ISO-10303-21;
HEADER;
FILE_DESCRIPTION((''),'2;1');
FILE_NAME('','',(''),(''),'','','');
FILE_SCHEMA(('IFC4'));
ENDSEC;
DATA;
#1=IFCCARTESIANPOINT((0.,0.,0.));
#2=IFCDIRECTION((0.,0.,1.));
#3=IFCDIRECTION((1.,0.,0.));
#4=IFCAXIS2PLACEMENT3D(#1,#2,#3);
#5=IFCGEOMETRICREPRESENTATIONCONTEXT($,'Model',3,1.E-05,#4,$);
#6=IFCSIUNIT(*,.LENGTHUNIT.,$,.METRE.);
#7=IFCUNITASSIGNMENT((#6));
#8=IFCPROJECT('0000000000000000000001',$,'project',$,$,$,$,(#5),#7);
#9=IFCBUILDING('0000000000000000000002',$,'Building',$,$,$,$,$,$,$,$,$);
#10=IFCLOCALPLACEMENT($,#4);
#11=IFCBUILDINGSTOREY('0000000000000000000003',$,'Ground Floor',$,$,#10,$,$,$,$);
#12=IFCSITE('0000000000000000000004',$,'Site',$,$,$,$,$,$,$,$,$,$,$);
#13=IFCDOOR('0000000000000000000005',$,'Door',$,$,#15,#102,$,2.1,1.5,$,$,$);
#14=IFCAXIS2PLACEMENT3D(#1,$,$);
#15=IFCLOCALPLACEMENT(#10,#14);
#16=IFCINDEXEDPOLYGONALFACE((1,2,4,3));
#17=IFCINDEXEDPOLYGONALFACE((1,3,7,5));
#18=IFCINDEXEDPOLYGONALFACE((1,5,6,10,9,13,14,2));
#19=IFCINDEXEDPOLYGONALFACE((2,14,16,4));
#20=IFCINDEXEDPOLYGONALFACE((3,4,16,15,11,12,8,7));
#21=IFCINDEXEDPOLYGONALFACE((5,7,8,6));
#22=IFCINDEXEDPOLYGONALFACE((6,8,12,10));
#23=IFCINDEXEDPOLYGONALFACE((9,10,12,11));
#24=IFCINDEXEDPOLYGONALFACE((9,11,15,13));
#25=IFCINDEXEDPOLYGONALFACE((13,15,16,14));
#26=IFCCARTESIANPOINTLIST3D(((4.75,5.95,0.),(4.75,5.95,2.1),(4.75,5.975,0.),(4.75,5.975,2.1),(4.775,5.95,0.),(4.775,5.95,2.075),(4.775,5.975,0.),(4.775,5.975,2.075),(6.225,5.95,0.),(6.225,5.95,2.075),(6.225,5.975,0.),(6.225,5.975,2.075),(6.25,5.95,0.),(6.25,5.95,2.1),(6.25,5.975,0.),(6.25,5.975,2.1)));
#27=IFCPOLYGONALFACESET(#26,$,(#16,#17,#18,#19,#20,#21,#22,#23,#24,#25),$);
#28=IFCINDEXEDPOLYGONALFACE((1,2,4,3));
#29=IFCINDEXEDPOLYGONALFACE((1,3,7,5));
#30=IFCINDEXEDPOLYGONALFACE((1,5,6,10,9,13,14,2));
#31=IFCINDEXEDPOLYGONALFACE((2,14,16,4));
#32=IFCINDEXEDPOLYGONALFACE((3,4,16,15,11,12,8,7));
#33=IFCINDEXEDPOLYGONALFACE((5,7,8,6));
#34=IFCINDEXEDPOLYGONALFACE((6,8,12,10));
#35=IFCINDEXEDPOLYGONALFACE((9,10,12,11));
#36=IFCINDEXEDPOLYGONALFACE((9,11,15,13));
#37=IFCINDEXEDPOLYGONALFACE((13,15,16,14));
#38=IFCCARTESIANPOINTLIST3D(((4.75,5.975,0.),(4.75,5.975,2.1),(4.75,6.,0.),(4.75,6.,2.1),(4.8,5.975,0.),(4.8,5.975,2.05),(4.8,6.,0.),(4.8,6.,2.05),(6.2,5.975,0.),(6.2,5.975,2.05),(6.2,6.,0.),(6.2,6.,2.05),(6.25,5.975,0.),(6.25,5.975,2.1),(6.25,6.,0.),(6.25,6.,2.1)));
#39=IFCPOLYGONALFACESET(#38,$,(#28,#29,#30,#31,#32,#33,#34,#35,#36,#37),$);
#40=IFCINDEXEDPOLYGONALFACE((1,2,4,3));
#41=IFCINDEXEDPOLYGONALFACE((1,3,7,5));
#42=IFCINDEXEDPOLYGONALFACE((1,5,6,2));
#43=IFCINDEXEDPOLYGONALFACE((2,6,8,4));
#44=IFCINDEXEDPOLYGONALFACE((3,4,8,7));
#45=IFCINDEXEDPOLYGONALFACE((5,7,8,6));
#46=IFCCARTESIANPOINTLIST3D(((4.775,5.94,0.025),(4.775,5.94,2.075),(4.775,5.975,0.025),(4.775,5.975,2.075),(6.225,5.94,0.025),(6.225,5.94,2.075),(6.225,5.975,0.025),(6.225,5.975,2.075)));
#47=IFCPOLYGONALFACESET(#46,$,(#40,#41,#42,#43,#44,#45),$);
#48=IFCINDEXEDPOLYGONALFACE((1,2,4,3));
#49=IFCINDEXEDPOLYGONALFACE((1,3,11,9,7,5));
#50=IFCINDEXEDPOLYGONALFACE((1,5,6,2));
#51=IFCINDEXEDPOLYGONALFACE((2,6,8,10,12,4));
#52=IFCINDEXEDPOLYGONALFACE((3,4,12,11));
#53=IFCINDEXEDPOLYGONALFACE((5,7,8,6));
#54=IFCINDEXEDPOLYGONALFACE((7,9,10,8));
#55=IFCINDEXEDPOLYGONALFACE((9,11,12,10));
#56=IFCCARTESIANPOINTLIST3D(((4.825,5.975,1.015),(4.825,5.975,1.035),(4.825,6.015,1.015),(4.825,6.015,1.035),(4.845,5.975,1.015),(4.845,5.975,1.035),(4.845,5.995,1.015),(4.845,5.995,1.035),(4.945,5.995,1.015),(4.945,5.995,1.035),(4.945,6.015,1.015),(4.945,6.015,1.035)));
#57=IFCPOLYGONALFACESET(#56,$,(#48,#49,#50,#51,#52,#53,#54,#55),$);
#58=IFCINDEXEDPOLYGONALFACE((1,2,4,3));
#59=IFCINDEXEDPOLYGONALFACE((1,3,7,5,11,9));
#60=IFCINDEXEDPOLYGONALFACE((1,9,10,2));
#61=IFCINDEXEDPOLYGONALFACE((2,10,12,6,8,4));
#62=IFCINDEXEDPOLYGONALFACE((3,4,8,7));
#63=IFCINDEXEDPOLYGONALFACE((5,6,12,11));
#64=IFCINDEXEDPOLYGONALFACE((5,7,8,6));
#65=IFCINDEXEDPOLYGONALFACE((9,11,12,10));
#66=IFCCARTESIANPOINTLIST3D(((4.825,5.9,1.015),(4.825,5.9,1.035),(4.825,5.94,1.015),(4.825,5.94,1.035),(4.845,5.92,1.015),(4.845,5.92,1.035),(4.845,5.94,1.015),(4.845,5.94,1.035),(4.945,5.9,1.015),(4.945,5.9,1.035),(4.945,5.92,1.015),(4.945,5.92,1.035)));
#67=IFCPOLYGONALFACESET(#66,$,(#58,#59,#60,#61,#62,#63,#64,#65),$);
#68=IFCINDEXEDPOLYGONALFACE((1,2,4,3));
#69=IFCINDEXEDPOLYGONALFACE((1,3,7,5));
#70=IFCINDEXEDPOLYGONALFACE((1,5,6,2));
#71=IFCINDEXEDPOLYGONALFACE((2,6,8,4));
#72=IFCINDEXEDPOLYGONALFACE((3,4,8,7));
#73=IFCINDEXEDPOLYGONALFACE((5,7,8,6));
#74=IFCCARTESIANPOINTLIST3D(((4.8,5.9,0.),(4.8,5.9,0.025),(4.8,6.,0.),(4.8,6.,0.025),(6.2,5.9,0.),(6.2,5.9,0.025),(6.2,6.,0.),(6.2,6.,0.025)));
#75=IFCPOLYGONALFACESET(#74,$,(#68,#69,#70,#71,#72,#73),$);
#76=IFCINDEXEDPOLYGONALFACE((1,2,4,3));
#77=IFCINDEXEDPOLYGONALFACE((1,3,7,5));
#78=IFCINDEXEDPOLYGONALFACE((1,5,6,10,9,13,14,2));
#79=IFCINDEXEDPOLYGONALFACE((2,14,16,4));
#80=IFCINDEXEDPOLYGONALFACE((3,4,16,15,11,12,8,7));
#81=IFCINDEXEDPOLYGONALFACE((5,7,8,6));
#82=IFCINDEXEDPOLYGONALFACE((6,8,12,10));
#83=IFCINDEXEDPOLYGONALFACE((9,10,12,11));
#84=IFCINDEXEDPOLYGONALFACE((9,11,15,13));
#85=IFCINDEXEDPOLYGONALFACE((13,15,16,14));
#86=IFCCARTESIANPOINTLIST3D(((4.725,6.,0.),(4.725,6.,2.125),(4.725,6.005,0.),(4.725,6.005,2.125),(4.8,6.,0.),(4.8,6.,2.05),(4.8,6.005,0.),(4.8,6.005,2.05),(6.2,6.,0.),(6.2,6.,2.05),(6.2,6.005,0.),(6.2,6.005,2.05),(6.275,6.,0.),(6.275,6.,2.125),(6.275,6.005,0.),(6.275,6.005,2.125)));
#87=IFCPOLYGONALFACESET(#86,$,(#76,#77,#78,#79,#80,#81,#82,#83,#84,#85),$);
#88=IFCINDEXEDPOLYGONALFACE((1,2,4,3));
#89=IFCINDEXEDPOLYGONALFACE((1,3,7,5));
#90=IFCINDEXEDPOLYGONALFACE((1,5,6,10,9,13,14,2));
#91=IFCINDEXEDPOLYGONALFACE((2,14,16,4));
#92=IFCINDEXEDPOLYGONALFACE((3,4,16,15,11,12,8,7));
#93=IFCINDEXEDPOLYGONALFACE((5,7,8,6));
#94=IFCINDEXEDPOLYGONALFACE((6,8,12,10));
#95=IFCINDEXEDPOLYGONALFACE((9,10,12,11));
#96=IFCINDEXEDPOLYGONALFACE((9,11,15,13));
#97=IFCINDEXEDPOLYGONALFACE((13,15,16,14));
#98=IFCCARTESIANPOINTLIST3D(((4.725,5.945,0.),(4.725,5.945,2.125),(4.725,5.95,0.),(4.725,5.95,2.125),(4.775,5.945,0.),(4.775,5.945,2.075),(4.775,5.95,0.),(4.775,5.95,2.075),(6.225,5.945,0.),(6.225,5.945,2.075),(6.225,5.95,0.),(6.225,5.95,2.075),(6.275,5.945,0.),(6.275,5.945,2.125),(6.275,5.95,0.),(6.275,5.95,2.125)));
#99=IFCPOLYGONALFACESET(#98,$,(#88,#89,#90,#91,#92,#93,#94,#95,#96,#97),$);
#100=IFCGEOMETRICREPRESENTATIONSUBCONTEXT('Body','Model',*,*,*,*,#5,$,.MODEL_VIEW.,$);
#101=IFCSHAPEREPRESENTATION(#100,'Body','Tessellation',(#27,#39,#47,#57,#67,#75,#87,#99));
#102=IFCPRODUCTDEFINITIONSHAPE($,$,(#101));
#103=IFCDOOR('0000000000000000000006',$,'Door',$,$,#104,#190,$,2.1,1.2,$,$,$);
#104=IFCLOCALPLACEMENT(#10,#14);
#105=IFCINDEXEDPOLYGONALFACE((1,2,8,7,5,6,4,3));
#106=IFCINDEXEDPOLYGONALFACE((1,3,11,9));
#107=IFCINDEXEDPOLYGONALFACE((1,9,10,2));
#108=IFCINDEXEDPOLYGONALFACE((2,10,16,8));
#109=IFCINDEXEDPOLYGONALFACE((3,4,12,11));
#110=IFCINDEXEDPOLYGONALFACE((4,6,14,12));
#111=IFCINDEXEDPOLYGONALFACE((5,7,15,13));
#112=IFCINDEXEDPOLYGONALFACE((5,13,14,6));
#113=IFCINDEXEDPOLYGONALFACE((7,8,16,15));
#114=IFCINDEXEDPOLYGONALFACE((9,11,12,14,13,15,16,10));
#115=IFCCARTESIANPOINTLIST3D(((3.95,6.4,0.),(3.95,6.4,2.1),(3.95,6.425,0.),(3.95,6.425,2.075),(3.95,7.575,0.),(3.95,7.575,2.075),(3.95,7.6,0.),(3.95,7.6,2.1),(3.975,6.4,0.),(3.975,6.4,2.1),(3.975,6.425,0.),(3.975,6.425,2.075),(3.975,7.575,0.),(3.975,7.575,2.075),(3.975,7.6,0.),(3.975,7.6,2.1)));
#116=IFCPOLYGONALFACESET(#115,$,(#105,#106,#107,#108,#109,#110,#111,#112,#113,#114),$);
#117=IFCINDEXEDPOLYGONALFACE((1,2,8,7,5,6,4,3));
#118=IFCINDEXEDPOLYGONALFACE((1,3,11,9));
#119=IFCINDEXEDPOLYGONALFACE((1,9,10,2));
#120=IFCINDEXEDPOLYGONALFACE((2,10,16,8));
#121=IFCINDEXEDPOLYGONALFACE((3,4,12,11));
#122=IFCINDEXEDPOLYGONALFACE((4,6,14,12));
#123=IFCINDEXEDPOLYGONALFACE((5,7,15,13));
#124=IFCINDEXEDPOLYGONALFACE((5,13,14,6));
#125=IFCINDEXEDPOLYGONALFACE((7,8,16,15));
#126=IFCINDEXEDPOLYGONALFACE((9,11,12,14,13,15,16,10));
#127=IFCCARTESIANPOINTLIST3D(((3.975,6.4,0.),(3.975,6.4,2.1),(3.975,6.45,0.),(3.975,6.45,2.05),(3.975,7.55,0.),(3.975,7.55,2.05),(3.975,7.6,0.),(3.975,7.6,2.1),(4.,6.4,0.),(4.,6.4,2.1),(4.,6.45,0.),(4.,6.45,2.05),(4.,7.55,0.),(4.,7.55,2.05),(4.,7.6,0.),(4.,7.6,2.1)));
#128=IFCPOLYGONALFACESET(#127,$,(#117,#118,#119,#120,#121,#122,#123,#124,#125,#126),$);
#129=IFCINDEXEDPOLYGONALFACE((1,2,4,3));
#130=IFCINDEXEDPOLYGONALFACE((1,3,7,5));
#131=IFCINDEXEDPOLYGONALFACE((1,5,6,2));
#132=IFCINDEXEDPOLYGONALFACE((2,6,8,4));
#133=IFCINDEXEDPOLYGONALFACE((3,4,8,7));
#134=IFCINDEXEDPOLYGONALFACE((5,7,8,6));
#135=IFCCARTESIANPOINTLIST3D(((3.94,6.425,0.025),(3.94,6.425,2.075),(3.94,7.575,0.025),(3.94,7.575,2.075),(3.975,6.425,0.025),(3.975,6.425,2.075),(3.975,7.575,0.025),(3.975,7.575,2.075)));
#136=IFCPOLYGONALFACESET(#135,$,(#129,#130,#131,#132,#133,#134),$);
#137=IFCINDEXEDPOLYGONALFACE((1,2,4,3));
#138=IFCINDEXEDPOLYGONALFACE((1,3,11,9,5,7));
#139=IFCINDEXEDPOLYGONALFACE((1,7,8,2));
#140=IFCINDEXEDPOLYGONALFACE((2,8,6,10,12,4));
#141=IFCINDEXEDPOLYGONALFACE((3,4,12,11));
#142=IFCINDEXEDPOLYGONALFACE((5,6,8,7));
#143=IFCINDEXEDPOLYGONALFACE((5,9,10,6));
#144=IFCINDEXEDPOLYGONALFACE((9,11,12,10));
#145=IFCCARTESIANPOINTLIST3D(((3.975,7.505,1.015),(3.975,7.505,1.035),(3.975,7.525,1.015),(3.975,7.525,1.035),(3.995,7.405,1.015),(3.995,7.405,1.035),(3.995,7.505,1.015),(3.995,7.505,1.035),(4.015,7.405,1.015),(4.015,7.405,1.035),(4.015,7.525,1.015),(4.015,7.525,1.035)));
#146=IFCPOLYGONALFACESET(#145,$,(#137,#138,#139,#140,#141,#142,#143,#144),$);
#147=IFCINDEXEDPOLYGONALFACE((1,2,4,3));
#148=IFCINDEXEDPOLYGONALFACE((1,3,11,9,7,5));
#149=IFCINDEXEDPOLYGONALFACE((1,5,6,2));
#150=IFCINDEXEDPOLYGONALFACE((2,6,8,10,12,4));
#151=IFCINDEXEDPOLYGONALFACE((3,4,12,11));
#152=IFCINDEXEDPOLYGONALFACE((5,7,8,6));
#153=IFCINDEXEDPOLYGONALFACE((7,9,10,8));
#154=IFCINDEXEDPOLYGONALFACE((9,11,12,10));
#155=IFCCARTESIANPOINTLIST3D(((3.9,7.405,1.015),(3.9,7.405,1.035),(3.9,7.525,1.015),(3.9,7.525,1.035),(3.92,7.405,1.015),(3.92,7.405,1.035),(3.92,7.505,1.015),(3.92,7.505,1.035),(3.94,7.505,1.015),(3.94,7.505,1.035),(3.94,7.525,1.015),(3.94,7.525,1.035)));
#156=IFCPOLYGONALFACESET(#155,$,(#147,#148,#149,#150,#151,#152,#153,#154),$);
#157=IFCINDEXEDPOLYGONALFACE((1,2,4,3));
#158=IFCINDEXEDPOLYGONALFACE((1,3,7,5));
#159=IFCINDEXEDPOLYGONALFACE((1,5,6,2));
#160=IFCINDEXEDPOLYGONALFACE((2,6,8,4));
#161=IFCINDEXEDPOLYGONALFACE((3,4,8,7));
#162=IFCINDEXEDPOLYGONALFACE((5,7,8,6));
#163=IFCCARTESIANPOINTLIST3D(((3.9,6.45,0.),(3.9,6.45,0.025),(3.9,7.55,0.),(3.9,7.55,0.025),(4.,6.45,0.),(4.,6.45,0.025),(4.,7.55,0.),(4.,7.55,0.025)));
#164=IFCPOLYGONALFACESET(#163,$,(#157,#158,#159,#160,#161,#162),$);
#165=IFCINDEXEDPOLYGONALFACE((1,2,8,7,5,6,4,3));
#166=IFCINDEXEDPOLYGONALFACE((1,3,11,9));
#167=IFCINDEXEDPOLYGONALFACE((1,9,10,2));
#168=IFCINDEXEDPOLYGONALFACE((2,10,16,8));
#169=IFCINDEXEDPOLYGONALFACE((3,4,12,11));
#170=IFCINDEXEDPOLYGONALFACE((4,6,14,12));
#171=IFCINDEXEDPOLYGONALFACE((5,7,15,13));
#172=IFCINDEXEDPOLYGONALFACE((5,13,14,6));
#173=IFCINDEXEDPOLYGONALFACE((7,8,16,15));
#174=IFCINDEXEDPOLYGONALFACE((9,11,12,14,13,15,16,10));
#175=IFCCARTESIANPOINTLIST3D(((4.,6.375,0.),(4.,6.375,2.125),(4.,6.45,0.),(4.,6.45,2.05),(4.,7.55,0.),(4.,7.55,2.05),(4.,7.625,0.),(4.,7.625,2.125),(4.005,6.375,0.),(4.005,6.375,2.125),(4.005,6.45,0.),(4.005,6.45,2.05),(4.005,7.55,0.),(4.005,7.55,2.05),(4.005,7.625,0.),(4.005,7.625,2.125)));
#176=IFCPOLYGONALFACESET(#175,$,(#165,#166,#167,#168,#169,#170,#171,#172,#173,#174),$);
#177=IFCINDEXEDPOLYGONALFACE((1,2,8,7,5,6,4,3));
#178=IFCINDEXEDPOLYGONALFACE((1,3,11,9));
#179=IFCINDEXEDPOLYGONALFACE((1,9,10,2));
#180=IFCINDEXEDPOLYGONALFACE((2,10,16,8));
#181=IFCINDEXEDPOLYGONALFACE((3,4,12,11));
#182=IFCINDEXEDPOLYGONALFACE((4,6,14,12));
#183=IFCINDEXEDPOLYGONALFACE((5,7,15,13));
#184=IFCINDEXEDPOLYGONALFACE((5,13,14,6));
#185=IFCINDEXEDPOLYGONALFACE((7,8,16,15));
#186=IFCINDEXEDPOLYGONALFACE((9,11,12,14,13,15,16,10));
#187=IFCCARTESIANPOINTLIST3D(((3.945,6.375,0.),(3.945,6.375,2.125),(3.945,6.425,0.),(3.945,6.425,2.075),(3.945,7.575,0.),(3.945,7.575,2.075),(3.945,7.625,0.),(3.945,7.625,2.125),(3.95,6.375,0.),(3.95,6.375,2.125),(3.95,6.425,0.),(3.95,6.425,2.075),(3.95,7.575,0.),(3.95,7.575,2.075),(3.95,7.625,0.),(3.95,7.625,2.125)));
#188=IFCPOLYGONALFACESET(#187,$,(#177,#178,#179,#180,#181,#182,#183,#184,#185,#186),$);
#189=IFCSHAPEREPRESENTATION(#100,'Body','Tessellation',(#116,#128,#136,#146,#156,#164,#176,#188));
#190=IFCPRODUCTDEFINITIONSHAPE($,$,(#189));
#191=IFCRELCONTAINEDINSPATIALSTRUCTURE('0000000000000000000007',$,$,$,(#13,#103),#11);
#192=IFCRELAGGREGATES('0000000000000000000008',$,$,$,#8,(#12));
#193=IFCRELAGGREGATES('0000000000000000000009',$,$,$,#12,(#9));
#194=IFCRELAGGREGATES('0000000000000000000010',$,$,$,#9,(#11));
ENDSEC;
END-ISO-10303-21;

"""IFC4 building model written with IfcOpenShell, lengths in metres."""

from ifc_helpers import new_model, si_unit, frame, origin_with_axes, place, context, subcontext, project, spatial, line, indexed_curve, outline, extrude, element, save


model = new_model("IFC4")

# Units and contexts
model_context = context("Model", 3, precision=1e-05, world=origin_with_axes())
body_context = subcontext(model_context, "Body", "Model", "MODEL_VIEW")
ifc_project = project(units=[si_unit("LENGTHUNIT", "METRE")], contexts=[model_context])

# Site, building, storey
site = spatial("IfcSite", under=ifc_project, Name="Site")
building = spatial("IfcBuilding", under=site, Name="Building")
storey_placement = place(None, origin_with_axes())
storey = spatial("IfcBuildingStorey", under=building, at=storey_placement, Name="Ground Floor")

# Doors
door_1_placement = place(storey_placement, frame((6.25, 6.0, 0.0), z_axis=(0.0, 0.0, 1.0), x_axis=(-1.0, 0.0, 0.0)))
element("IfcDoor", 1, at=door_1_placement, inside=storey, Name="Door", OverallHeight=2.1, OverallWidth=1.5, context=body_context, shape_type="SweptSolid", body=[
    extrude(outline(indexed_curve([(0.0, 0.0), (0.0, 2.1), (1.5, 2.1), (1.5, 0.0), (1.475, 0.0), (1.475, 2.075), (0.025, 2.075), (0.025, 0.0)], segments=[line(1, 2, 3, 4, 5, 6, 7, 8, 1)])), frame((0.0, 0.025, 0.0), z_axis=(0.0, -1.0, 0.0), x_axis=(1.0, 0.0, 0.0)), (0.0, 0.0, -1.0), 0.025),
    extrude(outline(indexed_curve([(0.0, 0.0), (0.0, 2.1), (1.5, 2.1), (1.5, 0.0), (1.45, 0.0), (1.45, 2.05), (0.05, 2.05), (0.05, 0.0)], segments=[line(1, 2, 3, 4, 5, 6, 7, 8, 1)])), frame((0.0, 0.0, 0.0), z_axis=(0.0, -1.0, 0.0), x_axis=(1.0, 0.0, 0.0)), (0.0, 0.0, -1.0), 0.025),
    extrude(outline(indexed_curve([(0.0, 0.0), (1.45, 0.0), (1.45, 0.035), (0.0, 0.035)], segments=[line(1, 2, 3, 4, 1)])), frame((0.025, 0.025, 0.025), z_axis=(0.0, 0.0, 1.0), x_axis=(1.0, 0.0, 0.0)), (0.0, 0.0, 1.0), 2.05),
    extrude(outline(indexed_curve([(0.0, 0.0), (0.0, -0.04), (-0.12, -0.04), (-0.12, -0.02), (-0.02, -0.02), (-0.02, 0.0)], segments=[line(1, 2, 3, 4, 5, 6, 1)])), frame((1.425, 0.025, 1.015), z_axis=(0.0, 0.0, 1.0), x_axis=(1.0, 0.0, 0.0)), (0.0, 0.0, 1.0), 0.02),
    extrude(outline(indexed_curve([(0.0, 0.0), (0.0, 0.04), (-0.12, 0.04), (-0.12, 0.02), (-0.02, 0.02), (-0.02, 0.0)], segments=[line(1, 2, 3, 4, 5, 6, 1)])), frame((1.425, 0.06, 1.015), z_axis=(0.0, 0.0, 1.0), x_axis=(1.0, 0.0, 0.0)), (0.0, 0.0, 1.0), 0.02),
    extrude(outline(indexed_curve([(0.0, 0.0), (1.4, 0.0), (1.4, 0.1), (0.0, 0.1)], segments=[line(1, 2, 3, 4, 1)])), frame((0.05, 0.0, 0.0), z_axis=(0.0, 0.0, 1.0), x_axis=(1.0, 0.0, 0.0)), (0.0, 0.0, 1.0), 0.025),
    extrude(outline(indexed_curve([(0.0, 0.0), (0.0, 2.125), (1.55, 2.125), (1.55, 0.0), (1.475, 0.0), (1.475, 2.05), (0.075, 2.05), (0.075, 0.0)], segments=[line(1, 2, 3, 4, 5, 6, 7, 8, 1)])), frame((-0.025, -0.005, 0.0), z_axis=(0.0, -1.0, 0.0), x_axis=(1.0, 0.0, 0.0)), (0.0, 0.0, -1.0), 0.005),
    extrude(outline(indexed_curve([(0.0, 0.0), (0.0, 2.125), (1.55, 2.125), (1.55, 0.0), (1.5, 0.0), (1.5, 2.075), (0.05, 2.075), (0.05, 0.0)], segments=[line(1, 2, 3, 4, 5, 6, 7, 8, 1)])), frame((-0.025, 0.05, 0.0), z_axis=(0.0, -1.0, 0.0), x_axis=(1.0, 0.0, 0.0)), (0.0, 0.0, -1.0), 0.005),
])
door_2_placement = place(storey_placement, frame((4.0, 6.4, 0.0), z_axis=(0.0, 0.0, 1.0), x_axis=(0.0, 1.0, 0.0)))
element("IfcDoor", 2, at=door_2_placement, inside=storey, Name="Door", OverallHeight=2.1, OverallWidth=1.2, context=body_context, shape_type="SweptSolid", body=[
    extrude(outline(indexed_curve([(0.0, 0.0), (0.0, 2.1), (1.2, 2.1), (1.2, 0.0), (1.175, 0.0), (1.175, 2.075), (0.025, 2.075), (0.025, 0.0)], segments=[line(1, 2, 3, 4, 5, 6, 7, 8, 1)])), frame((0.0, 0.025, 0.0), z_axis=(0.0, -1.0, 0.0), x_axis=(1.0, 0.0, 0.0)), (0.0, 0.0, -1.0), 0.025),
    extrude(outline(indexed_curve([(0.0, 0.0), (0.0, 2.1), (1.2, 2.1), (1.2, 0.0), (1.15, 0.0), (1.15, 2.05), (0.05, 2.05), (0.05, 0.0)], segments=[line(1, 2, 3, 4, 5, 6, 7, 8, 1)])), frame((0.0, 0.0, 0.0), z_axis=(0.0, -1.0, 0.0), x_axis=(1.0, 0.0, 0.0)), (0.0, 0.0, -1.0), 0.025),
    extrude(outline(indexed_curve([(0.0, 0.0), (1.15, 0.0), (1.15, 0.035), (0.0, 0.035)], segments=[line(1, 2, 3, 4, 1)])), frame((0.025, 0.025, 0.025), z_axis=(0.0, 0.0, 1.0), x_axis=(1.0, 0.0, 0.0)), (0.0, 0.0, 1.0), 2.05),
    extrude(outline(indexed_curve([(0.0, 0.0), (0.0, -0.04), (-0.12, -0.04), (-0.12, -0.02), (-0.02, -0.02), (-0.02, 0.0)], segments=[line(1, 2, 3, 4, 5, 6, 1)])), frame((1.125, 0.025, 1.015), z_axis=(0.0, 0.0, 1.0), x_axis=(1.0, 0.0, 0.0)), (0.0, 0.0, 1.0), 0.02),
    extrude(outline(indexed_curve([(0.0, 0.0), (0.0, 0.04), (-0.12, 0.04), (-0.12, 0.02), (-0.02, 0.02), (-0.02, 0.0)], segments=[line(1, 2, 3, 4, 5, 6, 1)])), frame((1.125, 0.06, 1.015), z_axis=(0.0, 0.0, 1.0), x_axis=(1.0, 0.0, 0.0)), (0.0, 0.0, 1.0), 0.02),
    extrude(outline(indexed_curve([(0.0, 0.0), (1.1, 0.0), (1.1, 0.1), (0.0, 0.1)], segments=[line(1, 2, 3, 4, 1)])), frame((0.05, 0.0, 0.0), z_axis=(0.0, 0.0, 1.0), x_axis=(1.0, 0.0, 0.0)), (0.0, 0.0, 1.0), 0.025),
    extrude(outline(indexed_curve([(0.0, 0.0), (0.0, 2.125), (1.25, 2.125), (1.25, 0.0), (1.175, 0.0), (1.175, 2.05), (0.075, 2.05), (0.075, 0.0)], segments=[line(1, 2, 3, 4, 5, 6, 7, 8, 1)])), frame((-0.025, -0.005, 0.0), z_axis=(0.0, -1.0, 0.0), x_axis=(1.0, 0.0, 0.0)), (0.0, 0.0, -1.0), 0.005),
    extrude(outline(indexed_curve([(0.0, 0.0), (0.0, 2.125), (1.25, 2.125), (1.25, 0.0), (1.2, 0.0), (1.2, 2.075), (0.05, 2.075), (0.05, 0.0)], segments=[line(1, 2, 3, 4, 5, 6, 7, 8, 1)])), frame((-0.025, 0.05, 0.0), z_axis=(0.0, -1.0, 0.0), x_axis=(1.0, 0.0, 0.0)), (0.0, 0.0, -1.0), 0.005),
])

save(model, "model.ifc")
